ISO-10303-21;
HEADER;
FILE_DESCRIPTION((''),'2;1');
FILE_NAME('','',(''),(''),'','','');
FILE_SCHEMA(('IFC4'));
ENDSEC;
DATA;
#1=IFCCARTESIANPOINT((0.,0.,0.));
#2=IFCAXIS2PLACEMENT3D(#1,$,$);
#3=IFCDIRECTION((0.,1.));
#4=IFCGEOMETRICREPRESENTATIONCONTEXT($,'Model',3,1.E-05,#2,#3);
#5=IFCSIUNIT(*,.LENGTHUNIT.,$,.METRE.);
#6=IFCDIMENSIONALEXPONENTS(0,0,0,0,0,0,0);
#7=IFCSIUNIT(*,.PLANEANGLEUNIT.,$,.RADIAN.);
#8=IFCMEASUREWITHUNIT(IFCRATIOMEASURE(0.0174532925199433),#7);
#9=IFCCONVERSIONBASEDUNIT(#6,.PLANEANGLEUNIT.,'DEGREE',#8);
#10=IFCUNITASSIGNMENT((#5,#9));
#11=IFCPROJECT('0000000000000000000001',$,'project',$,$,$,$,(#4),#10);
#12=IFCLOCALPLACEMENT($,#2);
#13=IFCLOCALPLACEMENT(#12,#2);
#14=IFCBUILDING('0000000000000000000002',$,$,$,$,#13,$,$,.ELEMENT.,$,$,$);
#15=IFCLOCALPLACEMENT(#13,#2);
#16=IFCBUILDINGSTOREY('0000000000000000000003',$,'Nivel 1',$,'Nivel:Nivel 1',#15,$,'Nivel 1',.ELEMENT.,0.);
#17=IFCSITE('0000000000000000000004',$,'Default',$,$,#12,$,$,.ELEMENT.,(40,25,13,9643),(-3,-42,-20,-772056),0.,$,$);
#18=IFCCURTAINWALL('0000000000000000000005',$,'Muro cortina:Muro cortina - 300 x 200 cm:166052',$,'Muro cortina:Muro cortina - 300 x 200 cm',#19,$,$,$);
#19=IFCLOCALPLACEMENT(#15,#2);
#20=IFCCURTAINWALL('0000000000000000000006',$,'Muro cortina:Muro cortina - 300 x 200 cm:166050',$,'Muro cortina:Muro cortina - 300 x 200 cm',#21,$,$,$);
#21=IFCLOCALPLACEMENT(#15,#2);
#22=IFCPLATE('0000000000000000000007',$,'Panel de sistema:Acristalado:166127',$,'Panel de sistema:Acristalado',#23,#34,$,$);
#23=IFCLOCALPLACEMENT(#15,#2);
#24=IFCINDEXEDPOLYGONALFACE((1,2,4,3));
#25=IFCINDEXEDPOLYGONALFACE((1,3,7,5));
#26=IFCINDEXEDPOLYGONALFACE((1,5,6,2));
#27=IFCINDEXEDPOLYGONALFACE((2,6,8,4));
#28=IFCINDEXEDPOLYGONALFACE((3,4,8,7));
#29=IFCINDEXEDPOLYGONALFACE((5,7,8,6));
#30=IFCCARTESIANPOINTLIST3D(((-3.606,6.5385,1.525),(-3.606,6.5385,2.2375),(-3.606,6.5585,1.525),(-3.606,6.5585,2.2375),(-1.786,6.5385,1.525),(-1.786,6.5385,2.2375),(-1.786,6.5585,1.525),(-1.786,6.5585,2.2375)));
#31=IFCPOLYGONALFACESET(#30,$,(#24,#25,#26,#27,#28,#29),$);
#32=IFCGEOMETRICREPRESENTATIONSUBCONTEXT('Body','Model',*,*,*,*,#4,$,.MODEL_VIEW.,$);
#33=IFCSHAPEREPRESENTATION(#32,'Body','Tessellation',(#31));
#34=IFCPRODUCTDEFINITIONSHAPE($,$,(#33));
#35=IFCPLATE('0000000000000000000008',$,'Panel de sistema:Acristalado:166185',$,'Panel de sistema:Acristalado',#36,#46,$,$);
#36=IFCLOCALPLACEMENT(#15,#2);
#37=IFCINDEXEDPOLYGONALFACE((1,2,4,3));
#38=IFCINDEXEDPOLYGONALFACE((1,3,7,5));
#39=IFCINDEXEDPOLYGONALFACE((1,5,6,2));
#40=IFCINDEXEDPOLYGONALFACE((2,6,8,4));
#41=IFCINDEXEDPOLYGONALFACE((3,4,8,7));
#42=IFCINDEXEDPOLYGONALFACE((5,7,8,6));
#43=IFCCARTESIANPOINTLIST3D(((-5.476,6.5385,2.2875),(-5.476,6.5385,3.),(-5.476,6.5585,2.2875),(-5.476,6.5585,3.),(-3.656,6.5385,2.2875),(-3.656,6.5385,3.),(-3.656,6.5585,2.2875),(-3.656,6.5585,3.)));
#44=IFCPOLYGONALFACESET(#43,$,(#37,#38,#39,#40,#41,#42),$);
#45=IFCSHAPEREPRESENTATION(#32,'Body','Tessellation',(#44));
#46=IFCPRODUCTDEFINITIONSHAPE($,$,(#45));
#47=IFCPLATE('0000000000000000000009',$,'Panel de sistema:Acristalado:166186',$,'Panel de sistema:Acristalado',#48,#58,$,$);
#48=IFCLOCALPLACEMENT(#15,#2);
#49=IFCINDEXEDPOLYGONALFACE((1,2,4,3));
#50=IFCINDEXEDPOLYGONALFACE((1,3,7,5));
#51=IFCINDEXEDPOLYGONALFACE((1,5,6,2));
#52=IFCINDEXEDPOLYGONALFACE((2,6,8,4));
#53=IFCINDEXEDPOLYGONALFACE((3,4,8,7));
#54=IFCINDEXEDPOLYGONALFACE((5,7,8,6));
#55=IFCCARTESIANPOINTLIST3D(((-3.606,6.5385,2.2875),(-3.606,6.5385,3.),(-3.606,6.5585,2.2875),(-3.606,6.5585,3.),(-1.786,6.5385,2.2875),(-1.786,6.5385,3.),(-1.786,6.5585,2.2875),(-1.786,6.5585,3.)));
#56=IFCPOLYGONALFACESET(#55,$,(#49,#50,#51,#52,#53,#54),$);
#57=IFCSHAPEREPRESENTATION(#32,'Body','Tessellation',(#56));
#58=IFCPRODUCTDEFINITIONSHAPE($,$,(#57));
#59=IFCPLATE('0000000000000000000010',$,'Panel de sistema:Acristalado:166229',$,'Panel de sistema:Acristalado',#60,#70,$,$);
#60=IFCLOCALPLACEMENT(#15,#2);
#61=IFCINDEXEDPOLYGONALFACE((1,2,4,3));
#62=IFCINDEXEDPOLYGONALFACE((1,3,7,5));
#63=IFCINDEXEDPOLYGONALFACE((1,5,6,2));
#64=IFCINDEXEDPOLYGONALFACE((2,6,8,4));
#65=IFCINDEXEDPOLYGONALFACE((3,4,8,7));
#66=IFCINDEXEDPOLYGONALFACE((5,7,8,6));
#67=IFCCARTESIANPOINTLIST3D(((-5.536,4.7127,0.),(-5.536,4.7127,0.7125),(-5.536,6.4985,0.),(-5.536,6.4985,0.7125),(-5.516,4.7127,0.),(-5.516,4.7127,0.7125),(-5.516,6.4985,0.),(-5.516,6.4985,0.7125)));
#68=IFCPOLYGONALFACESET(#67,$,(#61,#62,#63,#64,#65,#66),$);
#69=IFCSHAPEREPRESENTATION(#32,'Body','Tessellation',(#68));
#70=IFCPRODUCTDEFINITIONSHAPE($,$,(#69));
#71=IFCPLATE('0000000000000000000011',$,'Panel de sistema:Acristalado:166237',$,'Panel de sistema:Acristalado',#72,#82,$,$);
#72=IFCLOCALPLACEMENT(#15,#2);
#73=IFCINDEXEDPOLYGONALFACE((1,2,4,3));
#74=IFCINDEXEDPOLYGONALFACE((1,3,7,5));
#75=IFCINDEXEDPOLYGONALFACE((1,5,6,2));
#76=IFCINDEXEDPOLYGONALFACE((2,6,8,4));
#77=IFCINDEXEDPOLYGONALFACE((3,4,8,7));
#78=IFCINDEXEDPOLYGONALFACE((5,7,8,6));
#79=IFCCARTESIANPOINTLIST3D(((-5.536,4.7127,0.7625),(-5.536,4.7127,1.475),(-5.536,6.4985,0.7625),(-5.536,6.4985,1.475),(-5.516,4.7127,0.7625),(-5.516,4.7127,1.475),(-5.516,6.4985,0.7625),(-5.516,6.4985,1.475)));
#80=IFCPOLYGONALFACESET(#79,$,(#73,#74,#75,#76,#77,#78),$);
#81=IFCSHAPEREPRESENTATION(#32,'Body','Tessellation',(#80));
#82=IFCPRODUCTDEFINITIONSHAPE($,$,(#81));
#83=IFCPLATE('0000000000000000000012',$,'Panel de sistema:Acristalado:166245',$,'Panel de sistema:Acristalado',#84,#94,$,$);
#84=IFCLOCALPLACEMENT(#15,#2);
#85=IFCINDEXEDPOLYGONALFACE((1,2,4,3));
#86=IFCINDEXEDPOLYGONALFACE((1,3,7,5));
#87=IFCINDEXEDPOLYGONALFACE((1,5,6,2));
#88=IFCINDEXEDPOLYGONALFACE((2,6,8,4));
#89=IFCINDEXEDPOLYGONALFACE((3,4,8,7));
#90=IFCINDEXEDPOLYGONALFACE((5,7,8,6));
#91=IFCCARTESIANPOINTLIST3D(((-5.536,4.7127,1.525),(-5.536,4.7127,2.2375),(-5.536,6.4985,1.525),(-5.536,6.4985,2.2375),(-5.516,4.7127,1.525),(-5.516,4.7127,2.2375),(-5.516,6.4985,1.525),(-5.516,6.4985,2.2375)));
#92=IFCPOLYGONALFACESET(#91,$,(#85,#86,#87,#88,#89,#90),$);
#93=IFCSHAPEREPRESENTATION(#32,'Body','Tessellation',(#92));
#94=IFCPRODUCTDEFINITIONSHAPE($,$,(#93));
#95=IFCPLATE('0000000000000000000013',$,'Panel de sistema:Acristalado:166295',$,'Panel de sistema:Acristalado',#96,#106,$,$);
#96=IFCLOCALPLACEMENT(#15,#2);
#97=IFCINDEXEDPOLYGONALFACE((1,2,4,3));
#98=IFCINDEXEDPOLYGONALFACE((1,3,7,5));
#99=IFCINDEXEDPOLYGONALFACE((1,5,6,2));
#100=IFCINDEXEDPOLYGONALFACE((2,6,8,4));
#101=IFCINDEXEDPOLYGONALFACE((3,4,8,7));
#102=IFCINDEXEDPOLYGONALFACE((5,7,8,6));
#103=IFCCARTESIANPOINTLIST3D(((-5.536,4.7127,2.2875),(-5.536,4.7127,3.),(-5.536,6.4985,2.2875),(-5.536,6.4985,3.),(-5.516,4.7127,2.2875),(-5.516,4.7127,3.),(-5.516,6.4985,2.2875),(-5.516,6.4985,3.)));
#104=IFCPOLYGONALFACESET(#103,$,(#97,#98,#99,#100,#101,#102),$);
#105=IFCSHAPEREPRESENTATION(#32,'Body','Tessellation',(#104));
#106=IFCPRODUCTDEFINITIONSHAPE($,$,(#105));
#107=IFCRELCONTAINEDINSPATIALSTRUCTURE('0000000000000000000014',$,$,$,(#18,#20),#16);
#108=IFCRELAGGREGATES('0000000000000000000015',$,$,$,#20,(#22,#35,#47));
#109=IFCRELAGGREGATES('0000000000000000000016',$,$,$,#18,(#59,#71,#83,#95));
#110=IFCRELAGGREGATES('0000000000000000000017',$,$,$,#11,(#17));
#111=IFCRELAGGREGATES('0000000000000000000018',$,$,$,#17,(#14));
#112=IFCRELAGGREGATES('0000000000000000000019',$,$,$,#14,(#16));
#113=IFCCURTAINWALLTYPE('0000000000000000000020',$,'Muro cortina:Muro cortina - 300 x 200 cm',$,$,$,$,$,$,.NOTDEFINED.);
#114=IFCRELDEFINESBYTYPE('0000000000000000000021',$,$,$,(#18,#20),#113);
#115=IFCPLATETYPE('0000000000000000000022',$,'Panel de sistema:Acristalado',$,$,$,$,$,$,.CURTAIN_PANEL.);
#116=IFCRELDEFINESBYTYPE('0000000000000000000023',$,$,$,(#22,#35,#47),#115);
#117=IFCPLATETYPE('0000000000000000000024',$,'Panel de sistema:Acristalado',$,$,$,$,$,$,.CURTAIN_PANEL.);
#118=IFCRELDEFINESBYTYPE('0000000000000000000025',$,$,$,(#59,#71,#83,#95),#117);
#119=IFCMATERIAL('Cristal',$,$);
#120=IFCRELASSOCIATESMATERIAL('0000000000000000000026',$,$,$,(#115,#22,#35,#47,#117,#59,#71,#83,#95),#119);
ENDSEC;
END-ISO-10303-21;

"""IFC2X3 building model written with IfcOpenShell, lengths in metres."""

from ifc_helpers import new_model, entity, si_unit, converted_unit, direction, frame, origin, origin_2d_with_axis, place, context, subcontext, project, spatial, rectangle, extrude, source, transform, mapped, material, type_object, type_shapes, element, aggregate, save


model = new_model("IFC2X3")

# Units and contexts
model_context = context("Model", 3, precision=1e-05, world=origin(), true_north=direction((0.0, 1.0)))
body_context = subcontext(model_context, "Body", "Model", "MODEL_VIEW")
ifc_project = project(units=[si_unit("LENGTHUNIT", "METRE"), converted_unit("PLANEANGLEUNIT", "DEGREE", entity("IfcRatioMeasure", 0.0174532925199433), si_unit("PLANEANGLEUNIT", "RADIAN"), dimensions=[0, 0, 0, 0, 0, 0, 0])], contexts=[model_context])

# Site, building, storey
site_placement = place(None, origin())
site = spatial("IfcSite", under=ifc_project, at=site_placement, Name="Default", CompositionType="ELEMENT", RefLatitude=(40, 25, 13, 9643), RefLongitude=(-3, -42, -20, -772056), RefElevation=0.0)
building_placement = place(site_placement, origin())
building = spatial("IfcBuilding", under=site, at=building_placement, CompositionType="ELEMENT")
storey_placement = place(building_placement, origin())
storey = spatial("IfcBuildingStorey", under=building, at=storey_placement, Name="Nivel 1", ObjectType="Nivel:Nivel 1", LongName="Nivel 1", CompositionType="ELEMENT", Elevation=0.0)

# Curtain walls
curtain_wall_type = type_object("IfcCurtainWallType", Name="Muro cortina:Muro cortina - 300 x 200 cm", PredefinedType="NOTDEFINED")
curtain_wall_1_placement = place(storey_placement, origin())
curtain_wall_1 = element("IfcCurtainWall", 1, at=curtain_wall_1_placement, inside=storey, type_object=curtain_wall_type, Name="Muro cortina:Muro cortina - 300 x 200 cm:166052", ObjectType="Muro cortina:Muro cortina - 300 x 200 cm")
curtain_wall_2_placement = place(storey_placement, origin())
curtain_wall_2 = element("IfcCurtainWall", 2, at=curtain_wall_2_placement, inside=storey, type_object=curtain_wall_type, Name="Muro cortina:Muro cortina - 300 x 200 cm:166050", ObjectType="Muro cortina:Muro cortina - 300 x 200 cm")

# Plates
ifc_material_1 = material(Name="Cristal")
plate_type_1 = type_object("IfcPlateType", Name="Panel de sistema:Acristalado", PredefinedType="CURTAIN_PANEL", material=ifc_material_1)
shared_shape_1 = source(origin(), body_context, "Body", "SweptSolid", [
    extrude(rectangle(XDim=0.02, YDim=1.82, at=origin_2d_with_axis()), frame((0.0, 0.0, 0.0), z_axis=(0.0, 0.0, 1.0), x_axis=(0.0, 1.0, 0.0)), (0.0, 0.0, 1.0), 0.7125),
])
type_shapes(plate_type_1, [shared_shape_1])
plate_1_placement = place(curtain_wall_2_placement, frame((-2.696, 6.5485, 1.525)))
plate_1 = element("IfcPlate", 3, at=plate_1_placement, type_object=plate_type_1, material=ifc_material_1, Name="Panel de sistema:Acristalado:166127", ObjectType="Panel de sistema:Acristalado", context=body_context, shape_type="MappedRepresentation", body=[
    mapped(shared_shape_1, transform((0.0, 0.0, 0.0), scale=1.0)),
])
plate_2_placement = place(curtain_wall_2_placement, frame((-4.566, 6.5485, 2.2875)))
plate_2 = element("IfcPlate", 4, at=plate_2_placement, type_object=plate_type_1, material=ifc_material_1, Name="Panel de sistema:Acristalado:166185", ObjectType="Panel de sistema:Acristalado", context=body_context, shape_type="MappedRepresentation", body=[
    mapped(shared_shape_1, transform((0.0, 0.0, 0.0), scale=1.0)),
])
plate_3_placement = place(curtain_wall_2_placement, frame((-2.696, 6.5485, 2.2875)))
plate_3 = element("IfcPlate", 5, at=plate_3_placement, type_object=plate_type_1, material=ifc_material_1, Name="Panel de sistema:Acristalado:166186", ObjectType="Panel de sistema:Acristalado", context=body_context, shape_type="MappedRepresentation", body=[
    mapped(shared_shape_1, transform((0.0, 0.0, 0.0), scale=1.0)),
])
aggregate(curtain_wall_2, [plate_1, plate_2, plate_3])
plate_type_2 = type_object("IfcPlateType", Name="Panel de sistema:Acristalado", PredefinedType="CURTAIN_PANEL", material=ifc_material_1)
shared_shape_2 = source(origin(), body_context, "Body", "SweptSolid", [
    extrude(rectangle(XDim=0.02, YDim=1.7857, at=origin_2d_with_axis()), frame((0.0, 0.0, 0.0), z_axis=(0.0, 0.0, 1.0), x_axis=(0.0, 1.0, 0.0)), (0.0, 0.0, 1.0), 0.7125),
])
type_shapes(plate_type_2, [shared_shape_2])
plate_4_placement = place(curtain_wall_1_placement, frame((-5.526, 5.6056, 0.0), z_axis=(0.0, 0.0, 1.0), x_axis=(0.0, 1.0, 0.0)))
plate_4 = element("IfcPlate", 6, at=plate_4_placement, type_object=plate_type_2, material=ifc_material_1, Name="Panel de sistema:Acristalado:166229", ObjectType="Panel de sistema:Acristalado", context=body_context, shape_type="MappedRepresentation", body=[
    mapped(shared_shape_2, transform((0.0, 0.0, 0.0), scale=1.0)),
])
plate_5_placement = place(curtain_wall_1_placement, frame((-5.526, 5.6056, 0.7625), z_axis=(0.0, 0.0, 1.0), x_axis=(0.0, 1.0, 0.0)))
plate_5 = element("IfcPlate", 7, at=plate_5_placement, type_object=plate_type_2, material=ifc_material_1, Name="Panel de sistema:Acristalado:166237", ObjectType="Panel de sistema:Acristalado", context=body_context, shape_type="MappedRepresentation", body=[
    mapped(shared_shape_2, transform((0.0, 0.0, 0.0), scale=1.0)),
])
plate_6_placement = place(curtain_wall_1_placement, frame((-5.526, 5.6056, 1.525), z_axis=(0.0, 0.0, 1.0), x_axis=(0.0, 1.0, 0.0)))
plate_6 = element("IfcPlate", 8, at=plate_6_placement, type_object=plate_type_2, material=ifc_material_1, Name="Panel de sistema:Acristalado:166245", ObjectType="Panel de sistema:Acristalado", context=body_context, shape_type="MappedRepresentation", body=[
    mapped(shared_shape_2, transform((0.0, 0.0, 0.0), scale=1.0)),
])
plate_7_placement = place(curtain_wall_1_placement, frame((-5.526, 5.6056, 2.2875), z_axis=(0.0, 0.0, 1.0), x_axis=(0.0, 1.0, 0.0)))
plate_7 = element("IfcPlate", 9, at=plate_7_placement, type_object=plate_type_2, material=ifc_material_1, Name="Panel de sistema:Acristalado:166295", ObjectType="Panel de sistema:Acristalado", context=body_context, shape_type="MappedRepresentation", body=[
    mapped(shared_shape_2, transform((0.0, 0.0, 0.0), scale=1.0)),
])
aggregate(curtain_wall_1, [plate_4, plate_5, plate_6, plate_7])

save(model, "model.ifc")
